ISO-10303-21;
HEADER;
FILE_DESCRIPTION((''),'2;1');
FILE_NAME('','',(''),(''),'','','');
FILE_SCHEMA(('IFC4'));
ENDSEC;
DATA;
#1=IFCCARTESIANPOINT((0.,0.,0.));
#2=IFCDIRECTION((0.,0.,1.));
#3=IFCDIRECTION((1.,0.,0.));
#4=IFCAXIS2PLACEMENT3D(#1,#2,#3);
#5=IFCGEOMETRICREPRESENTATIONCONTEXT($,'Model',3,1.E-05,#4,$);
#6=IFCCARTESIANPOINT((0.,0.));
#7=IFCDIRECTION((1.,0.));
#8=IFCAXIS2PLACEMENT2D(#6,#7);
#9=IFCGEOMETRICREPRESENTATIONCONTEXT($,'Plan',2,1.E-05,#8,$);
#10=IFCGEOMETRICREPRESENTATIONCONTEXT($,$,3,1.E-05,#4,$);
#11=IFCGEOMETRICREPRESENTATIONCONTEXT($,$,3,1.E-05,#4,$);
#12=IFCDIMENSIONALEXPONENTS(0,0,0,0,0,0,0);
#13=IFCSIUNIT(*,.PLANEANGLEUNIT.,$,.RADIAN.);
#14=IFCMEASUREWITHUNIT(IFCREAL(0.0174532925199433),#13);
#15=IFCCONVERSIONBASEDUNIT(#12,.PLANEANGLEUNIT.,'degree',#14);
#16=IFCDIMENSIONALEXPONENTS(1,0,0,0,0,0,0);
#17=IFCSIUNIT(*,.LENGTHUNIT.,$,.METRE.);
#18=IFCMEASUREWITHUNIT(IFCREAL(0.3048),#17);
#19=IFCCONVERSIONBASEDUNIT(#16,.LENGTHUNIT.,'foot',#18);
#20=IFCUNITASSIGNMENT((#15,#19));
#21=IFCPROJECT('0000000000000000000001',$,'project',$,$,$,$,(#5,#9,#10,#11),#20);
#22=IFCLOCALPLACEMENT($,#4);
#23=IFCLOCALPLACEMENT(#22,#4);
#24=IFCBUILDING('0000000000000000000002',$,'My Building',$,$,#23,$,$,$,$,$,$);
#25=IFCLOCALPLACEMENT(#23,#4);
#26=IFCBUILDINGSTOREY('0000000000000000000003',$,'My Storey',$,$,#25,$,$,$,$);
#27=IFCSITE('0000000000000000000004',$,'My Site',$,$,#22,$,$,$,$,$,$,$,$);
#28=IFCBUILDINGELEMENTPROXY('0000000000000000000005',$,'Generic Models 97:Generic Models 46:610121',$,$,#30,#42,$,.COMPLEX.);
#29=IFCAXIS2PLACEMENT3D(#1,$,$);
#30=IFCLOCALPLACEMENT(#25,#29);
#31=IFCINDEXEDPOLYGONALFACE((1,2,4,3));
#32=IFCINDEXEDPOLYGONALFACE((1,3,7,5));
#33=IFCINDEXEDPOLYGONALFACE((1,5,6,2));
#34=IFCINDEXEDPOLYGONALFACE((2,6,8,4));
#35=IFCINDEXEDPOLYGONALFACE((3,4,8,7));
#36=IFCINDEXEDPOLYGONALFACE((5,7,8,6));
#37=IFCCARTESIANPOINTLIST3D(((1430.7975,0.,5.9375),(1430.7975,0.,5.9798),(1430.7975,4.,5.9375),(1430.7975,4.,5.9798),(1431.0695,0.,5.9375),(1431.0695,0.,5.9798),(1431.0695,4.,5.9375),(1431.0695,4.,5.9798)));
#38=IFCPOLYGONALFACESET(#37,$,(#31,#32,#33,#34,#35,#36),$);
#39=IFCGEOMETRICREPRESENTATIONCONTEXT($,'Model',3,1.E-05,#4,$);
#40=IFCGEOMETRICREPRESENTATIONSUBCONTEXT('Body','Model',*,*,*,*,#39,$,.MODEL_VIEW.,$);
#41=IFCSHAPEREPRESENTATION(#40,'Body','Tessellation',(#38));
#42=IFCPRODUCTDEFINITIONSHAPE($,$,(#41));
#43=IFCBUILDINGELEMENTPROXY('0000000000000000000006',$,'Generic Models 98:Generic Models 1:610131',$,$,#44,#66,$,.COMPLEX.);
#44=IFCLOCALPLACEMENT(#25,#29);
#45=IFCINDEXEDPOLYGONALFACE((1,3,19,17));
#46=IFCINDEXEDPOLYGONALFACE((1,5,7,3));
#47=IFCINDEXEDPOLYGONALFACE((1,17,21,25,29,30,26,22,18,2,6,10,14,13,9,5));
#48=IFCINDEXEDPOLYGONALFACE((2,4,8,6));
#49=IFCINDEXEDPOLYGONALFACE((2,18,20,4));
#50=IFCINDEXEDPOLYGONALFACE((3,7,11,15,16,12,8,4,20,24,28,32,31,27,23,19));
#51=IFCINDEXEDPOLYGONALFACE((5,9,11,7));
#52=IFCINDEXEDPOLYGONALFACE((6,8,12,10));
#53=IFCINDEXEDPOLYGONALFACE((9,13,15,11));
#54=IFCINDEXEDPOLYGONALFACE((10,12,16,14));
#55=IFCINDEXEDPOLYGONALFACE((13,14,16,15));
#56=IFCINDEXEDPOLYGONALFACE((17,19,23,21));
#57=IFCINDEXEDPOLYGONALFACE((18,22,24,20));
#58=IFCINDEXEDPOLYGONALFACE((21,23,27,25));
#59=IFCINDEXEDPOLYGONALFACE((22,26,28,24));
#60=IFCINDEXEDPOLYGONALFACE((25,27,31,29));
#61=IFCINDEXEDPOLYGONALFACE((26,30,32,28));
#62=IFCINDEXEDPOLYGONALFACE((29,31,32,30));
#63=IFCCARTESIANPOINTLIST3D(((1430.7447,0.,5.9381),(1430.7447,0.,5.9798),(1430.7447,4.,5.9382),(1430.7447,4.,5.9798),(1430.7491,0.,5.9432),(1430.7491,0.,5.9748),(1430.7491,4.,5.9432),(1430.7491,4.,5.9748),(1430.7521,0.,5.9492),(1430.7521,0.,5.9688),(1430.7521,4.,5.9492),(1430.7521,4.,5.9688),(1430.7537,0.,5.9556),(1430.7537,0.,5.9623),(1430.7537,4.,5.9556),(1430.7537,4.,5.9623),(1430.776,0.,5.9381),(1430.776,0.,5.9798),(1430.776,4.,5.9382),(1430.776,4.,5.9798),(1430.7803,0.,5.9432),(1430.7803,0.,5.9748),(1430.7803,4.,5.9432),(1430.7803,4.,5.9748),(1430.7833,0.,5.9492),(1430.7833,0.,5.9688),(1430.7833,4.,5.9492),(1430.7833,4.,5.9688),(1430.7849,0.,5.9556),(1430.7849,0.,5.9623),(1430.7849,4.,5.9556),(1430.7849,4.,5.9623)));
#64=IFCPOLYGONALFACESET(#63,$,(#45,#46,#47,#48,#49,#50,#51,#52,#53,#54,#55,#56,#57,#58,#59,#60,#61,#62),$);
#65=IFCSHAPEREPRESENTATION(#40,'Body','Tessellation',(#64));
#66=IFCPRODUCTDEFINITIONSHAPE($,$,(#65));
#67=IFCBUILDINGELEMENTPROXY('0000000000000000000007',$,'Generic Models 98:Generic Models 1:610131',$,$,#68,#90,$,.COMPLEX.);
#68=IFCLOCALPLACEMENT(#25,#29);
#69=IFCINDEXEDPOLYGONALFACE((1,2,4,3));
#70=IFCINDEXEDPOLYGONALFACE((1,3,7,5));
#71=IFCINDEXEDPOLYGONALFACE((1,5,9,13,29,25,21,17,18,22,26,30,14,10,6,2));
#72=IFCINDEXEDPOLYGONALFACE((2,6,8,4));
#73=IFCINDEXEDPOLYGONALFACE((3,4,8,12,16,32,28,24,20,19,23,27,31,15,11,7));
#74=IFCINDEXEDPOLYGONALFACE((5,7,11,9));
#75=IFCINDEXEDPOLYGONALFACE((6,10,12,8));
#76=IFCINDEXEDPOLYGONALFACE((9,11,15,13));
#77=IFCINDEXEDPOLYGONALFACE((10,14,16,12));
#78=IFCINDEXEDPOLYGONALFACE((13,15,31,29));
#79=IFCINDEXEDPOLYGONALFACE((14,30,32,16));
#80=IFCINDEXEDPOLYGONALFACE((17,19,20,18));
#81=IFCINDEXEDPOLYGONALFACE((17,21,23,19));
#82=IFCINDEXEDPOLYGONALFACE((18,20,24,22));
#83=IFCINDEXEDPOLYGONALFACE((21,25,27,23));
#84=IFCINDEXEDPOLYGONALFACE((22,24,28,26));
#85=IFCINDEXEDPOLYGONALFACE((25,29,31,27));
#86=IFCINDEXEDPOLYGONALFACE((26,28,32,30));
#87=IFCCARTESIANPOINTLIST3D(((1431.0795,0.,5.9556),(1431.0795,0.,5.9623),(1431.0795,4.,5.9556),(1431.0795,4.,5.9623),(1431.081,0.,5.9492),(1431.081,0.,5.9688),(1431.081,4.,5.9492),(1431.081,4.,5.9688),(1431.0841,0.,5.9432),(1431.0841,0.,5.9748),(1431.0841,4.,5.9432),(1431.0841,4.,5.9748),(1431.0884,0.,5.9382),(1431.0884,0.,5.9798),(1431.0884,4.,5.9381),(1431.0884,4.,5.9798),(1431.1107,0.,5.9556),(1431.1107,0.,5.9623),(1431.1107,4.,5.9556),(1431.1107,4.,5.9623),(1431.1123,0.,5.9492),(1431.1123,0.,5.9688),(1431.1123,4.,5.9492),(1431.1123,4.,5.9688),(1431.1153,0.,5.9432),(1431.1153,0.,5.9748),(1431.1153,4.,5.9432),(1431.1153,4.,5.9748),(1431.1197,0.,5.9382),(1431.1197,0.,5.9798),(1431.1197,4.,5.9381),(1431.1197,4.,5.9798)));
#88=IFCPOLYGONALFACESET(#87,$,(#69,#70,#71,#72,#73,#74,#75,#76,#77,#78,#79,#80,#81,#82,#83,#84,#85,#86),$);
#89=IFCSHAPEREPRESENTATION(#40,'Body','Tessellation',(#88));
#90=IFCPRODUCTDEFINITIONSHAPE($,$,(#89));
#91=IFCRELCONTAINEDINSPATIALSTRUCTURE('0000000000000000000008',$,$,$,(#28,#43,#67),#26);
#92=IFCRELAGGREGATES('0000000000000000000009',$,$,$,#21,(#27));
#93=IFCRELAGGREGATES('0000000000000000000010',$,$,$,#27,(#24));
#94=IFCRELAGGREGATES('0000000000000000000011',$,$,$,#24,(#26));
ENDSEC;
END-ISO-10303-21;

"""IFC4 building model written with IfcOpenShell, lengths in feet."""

from ifc_helpers import new_model, entity, si_unit, converted_unit, frame, origin_with_axes, origin_2d_with_axis, place, context, subcontext, project, spatial, polyline, line, indexed_curve, outline, extrude, element, save


model = new_model("IFC4")

# Units and contexts
model_context_1 = context("Model", 3, precision=1e-05, world=origin_with_axes())
plan_context = context("Plan", 2, precision=1e-05, world=origin_2d_with_axis())
model_context_2 = context("Model", 3, precision=1e-05, world=origin_with_axes())
context_of_model_1 = context(None, 3, precision=1e-05, world=origin_with_axes())
context_of_model_2 = context(None, 3, precision=1e-05, world=origin_with_axes())
body_context = subcontext(model_context_2, "Body", "Model", "MODEL_VIEW")
ifc_project = project(units=[converted_unit("PLANEANGLEUNIT", "degree", entity("IfcReal", 0.0174532925199433), si_unit("PLANEANGLEUNIT", "RADIAN"), dimensions=[0, 0, 0, 0, 0, 0, 0]), converted_unit("LENGTHUNIT", "foot", entity("IfcReal", 0.3048), si_unit("LENGTHUNIT", "METRE"), dimensions=[1, 0, 0, 0, 0, 0, 0])], contexts=[model_context_1, plan_context, context_of_model_1, context_of_model_2])

# Site, building, storey
site_placement = place(None, origin_with_axes())
site = spatial("IfcSite", under=ifc_project, at=site_placement, Name="My Site")
building_placement = place(site_placement, origin_with_axes())
building = spatial("IfcBuilding", under=site, at=building_placement, Name="My Building")
storey_placement = place(building_placement, origin_with_axes())
storey = spatial("IfcBuildingStorey", under=building, at=storey_placement, Name="My Storey")

# Building element proxies
proxy_1_placement = place(storey_placement, frame((1430.7975, 4.0, 5.9375), z_axis=(0.0, -1.0, 0.0), x_axis=(0.0, 0.0, 1.0)))
element("IfcBuildingElementProxy", 1, at=proxy_1_placement, inside=storey, Name="Generic Models 97:Generic Models 46:610121", PredefinedType="COMPLEX", context=body_context, shape_type="SweptSolid", body=[
    extrude(outline(polyline([(-0.0212, -0.136), (0.0212, -0.136), (0.0212, 0.136), (-0.0212, 0.136), (-0.0212, -0.136)])), frame((0.0212, -0.136, 0.0), z_axis=(0.0, 0.0, -1.0), x_axis=(-1.0, 0.0, 0.0)), (0.0, 0.0, -1.0), 4.0),
])
proxy_2_placement = place(storey_placement, frame((1430.7849, 3.847, 5.9382), z_axis=(0.0, 1.0, 0.0), x_axis=(0.0, 0.0, 1.0)))
element("IfcBuildingElementProxy", 2, at=proxy_2_placement, inside=storey, Name="Generic Models 98:Generic Models 1:610131", PredefinedType="COMPLEX", context=body_context, shape_type="SweptSolid", body=[
    extrude(outline(indexed_curve([(0.0115, 0.0043), (0.0166, 0.0), (0.0226, -0.003), (0.0291, -0.0045), (0.0039, -0.023), (-0.0026, -0.0215), (-0.0086, -0.0185), (-0.0137, -0.0142), (-0.0176, -0.0088), (-0.0202, -0.0026), (-0.0213, 0.004), (-0.0207, 0.0106), (0.0045, 0.0291), (0.0039, 0.0224), (0.005, 0.0159), (0.0076, 0.0097)], segments=[line(12, 11), line(11, 10), line(10, 9), line(9, 8), line(8, 7), line(7, 6), line(6, 5), line(5, 4), line(4, 3), line(3, 2), line(2, 1), line(1, 16), line(16, 15), line(15, 14), line(14, 13), line(13, 12)], self_intersect=False)), frame((0.0208, -0.0194, 0.153), z_axis=(0.0, 0.0, -1.0), x_axis=(0.591192, -0.806531, 0.000001)), (-0.000001, 0.0, 1.0), 4.0),
])
proxy_3_placement = place(storey_placement, frame((1431.0795, 3.847, 5.9798), z_axis=(0.0, 1.0, 0.0), x_axis=(0.0, 0.0, -1.0)))
element("IfcBuildingElementProxy", 3, at=proxy_3_placement, inside=storey, Name="Generic Models 98:Generic Models 1:610131", PredefinedType="COMPLEX", context=body_context, shape_type="SweptSolid", body=[
    extrude(outline(indexed_curve([(0.0115, 0.0043), (0.0166, 0.0), (0.0226, -0.003), (0.0291, -0.0045), (0.0039, -0.023), (-0.0026, -0.0215), (-0.0086, -0.0185), (-0.0137, -0.0142), (-0.0176, -0.0088), (-0.0202, -0.0026), (-0.0213, 0.004), (-0.0207, 0.0106), (0.0045, 0.0291), (0.0039, 0.0224), (0.005, 0.0159), (0.0076, 0.0097)], segments=[line(9, 8), line(8, 7), line(7, 6), line(6, 5), line(5, 4), line(4, 3), line(3, 2), line(2, 1), line(1, 16), line(16, 15), line(15, 14), line(14, 13), line(13, 12), line(12, 11), line(11, 10), line(10, 9)], self_intersect=False)), frame((0.0208, -0.0194, 0.153), z_axis=(0.0, 0.0, -1.0), x_axis=(0.591192, -0.806531, 0.000001)), (-0.000001, 0.0, 1.0), 4.0),
])

save(model, "model.ifc")
